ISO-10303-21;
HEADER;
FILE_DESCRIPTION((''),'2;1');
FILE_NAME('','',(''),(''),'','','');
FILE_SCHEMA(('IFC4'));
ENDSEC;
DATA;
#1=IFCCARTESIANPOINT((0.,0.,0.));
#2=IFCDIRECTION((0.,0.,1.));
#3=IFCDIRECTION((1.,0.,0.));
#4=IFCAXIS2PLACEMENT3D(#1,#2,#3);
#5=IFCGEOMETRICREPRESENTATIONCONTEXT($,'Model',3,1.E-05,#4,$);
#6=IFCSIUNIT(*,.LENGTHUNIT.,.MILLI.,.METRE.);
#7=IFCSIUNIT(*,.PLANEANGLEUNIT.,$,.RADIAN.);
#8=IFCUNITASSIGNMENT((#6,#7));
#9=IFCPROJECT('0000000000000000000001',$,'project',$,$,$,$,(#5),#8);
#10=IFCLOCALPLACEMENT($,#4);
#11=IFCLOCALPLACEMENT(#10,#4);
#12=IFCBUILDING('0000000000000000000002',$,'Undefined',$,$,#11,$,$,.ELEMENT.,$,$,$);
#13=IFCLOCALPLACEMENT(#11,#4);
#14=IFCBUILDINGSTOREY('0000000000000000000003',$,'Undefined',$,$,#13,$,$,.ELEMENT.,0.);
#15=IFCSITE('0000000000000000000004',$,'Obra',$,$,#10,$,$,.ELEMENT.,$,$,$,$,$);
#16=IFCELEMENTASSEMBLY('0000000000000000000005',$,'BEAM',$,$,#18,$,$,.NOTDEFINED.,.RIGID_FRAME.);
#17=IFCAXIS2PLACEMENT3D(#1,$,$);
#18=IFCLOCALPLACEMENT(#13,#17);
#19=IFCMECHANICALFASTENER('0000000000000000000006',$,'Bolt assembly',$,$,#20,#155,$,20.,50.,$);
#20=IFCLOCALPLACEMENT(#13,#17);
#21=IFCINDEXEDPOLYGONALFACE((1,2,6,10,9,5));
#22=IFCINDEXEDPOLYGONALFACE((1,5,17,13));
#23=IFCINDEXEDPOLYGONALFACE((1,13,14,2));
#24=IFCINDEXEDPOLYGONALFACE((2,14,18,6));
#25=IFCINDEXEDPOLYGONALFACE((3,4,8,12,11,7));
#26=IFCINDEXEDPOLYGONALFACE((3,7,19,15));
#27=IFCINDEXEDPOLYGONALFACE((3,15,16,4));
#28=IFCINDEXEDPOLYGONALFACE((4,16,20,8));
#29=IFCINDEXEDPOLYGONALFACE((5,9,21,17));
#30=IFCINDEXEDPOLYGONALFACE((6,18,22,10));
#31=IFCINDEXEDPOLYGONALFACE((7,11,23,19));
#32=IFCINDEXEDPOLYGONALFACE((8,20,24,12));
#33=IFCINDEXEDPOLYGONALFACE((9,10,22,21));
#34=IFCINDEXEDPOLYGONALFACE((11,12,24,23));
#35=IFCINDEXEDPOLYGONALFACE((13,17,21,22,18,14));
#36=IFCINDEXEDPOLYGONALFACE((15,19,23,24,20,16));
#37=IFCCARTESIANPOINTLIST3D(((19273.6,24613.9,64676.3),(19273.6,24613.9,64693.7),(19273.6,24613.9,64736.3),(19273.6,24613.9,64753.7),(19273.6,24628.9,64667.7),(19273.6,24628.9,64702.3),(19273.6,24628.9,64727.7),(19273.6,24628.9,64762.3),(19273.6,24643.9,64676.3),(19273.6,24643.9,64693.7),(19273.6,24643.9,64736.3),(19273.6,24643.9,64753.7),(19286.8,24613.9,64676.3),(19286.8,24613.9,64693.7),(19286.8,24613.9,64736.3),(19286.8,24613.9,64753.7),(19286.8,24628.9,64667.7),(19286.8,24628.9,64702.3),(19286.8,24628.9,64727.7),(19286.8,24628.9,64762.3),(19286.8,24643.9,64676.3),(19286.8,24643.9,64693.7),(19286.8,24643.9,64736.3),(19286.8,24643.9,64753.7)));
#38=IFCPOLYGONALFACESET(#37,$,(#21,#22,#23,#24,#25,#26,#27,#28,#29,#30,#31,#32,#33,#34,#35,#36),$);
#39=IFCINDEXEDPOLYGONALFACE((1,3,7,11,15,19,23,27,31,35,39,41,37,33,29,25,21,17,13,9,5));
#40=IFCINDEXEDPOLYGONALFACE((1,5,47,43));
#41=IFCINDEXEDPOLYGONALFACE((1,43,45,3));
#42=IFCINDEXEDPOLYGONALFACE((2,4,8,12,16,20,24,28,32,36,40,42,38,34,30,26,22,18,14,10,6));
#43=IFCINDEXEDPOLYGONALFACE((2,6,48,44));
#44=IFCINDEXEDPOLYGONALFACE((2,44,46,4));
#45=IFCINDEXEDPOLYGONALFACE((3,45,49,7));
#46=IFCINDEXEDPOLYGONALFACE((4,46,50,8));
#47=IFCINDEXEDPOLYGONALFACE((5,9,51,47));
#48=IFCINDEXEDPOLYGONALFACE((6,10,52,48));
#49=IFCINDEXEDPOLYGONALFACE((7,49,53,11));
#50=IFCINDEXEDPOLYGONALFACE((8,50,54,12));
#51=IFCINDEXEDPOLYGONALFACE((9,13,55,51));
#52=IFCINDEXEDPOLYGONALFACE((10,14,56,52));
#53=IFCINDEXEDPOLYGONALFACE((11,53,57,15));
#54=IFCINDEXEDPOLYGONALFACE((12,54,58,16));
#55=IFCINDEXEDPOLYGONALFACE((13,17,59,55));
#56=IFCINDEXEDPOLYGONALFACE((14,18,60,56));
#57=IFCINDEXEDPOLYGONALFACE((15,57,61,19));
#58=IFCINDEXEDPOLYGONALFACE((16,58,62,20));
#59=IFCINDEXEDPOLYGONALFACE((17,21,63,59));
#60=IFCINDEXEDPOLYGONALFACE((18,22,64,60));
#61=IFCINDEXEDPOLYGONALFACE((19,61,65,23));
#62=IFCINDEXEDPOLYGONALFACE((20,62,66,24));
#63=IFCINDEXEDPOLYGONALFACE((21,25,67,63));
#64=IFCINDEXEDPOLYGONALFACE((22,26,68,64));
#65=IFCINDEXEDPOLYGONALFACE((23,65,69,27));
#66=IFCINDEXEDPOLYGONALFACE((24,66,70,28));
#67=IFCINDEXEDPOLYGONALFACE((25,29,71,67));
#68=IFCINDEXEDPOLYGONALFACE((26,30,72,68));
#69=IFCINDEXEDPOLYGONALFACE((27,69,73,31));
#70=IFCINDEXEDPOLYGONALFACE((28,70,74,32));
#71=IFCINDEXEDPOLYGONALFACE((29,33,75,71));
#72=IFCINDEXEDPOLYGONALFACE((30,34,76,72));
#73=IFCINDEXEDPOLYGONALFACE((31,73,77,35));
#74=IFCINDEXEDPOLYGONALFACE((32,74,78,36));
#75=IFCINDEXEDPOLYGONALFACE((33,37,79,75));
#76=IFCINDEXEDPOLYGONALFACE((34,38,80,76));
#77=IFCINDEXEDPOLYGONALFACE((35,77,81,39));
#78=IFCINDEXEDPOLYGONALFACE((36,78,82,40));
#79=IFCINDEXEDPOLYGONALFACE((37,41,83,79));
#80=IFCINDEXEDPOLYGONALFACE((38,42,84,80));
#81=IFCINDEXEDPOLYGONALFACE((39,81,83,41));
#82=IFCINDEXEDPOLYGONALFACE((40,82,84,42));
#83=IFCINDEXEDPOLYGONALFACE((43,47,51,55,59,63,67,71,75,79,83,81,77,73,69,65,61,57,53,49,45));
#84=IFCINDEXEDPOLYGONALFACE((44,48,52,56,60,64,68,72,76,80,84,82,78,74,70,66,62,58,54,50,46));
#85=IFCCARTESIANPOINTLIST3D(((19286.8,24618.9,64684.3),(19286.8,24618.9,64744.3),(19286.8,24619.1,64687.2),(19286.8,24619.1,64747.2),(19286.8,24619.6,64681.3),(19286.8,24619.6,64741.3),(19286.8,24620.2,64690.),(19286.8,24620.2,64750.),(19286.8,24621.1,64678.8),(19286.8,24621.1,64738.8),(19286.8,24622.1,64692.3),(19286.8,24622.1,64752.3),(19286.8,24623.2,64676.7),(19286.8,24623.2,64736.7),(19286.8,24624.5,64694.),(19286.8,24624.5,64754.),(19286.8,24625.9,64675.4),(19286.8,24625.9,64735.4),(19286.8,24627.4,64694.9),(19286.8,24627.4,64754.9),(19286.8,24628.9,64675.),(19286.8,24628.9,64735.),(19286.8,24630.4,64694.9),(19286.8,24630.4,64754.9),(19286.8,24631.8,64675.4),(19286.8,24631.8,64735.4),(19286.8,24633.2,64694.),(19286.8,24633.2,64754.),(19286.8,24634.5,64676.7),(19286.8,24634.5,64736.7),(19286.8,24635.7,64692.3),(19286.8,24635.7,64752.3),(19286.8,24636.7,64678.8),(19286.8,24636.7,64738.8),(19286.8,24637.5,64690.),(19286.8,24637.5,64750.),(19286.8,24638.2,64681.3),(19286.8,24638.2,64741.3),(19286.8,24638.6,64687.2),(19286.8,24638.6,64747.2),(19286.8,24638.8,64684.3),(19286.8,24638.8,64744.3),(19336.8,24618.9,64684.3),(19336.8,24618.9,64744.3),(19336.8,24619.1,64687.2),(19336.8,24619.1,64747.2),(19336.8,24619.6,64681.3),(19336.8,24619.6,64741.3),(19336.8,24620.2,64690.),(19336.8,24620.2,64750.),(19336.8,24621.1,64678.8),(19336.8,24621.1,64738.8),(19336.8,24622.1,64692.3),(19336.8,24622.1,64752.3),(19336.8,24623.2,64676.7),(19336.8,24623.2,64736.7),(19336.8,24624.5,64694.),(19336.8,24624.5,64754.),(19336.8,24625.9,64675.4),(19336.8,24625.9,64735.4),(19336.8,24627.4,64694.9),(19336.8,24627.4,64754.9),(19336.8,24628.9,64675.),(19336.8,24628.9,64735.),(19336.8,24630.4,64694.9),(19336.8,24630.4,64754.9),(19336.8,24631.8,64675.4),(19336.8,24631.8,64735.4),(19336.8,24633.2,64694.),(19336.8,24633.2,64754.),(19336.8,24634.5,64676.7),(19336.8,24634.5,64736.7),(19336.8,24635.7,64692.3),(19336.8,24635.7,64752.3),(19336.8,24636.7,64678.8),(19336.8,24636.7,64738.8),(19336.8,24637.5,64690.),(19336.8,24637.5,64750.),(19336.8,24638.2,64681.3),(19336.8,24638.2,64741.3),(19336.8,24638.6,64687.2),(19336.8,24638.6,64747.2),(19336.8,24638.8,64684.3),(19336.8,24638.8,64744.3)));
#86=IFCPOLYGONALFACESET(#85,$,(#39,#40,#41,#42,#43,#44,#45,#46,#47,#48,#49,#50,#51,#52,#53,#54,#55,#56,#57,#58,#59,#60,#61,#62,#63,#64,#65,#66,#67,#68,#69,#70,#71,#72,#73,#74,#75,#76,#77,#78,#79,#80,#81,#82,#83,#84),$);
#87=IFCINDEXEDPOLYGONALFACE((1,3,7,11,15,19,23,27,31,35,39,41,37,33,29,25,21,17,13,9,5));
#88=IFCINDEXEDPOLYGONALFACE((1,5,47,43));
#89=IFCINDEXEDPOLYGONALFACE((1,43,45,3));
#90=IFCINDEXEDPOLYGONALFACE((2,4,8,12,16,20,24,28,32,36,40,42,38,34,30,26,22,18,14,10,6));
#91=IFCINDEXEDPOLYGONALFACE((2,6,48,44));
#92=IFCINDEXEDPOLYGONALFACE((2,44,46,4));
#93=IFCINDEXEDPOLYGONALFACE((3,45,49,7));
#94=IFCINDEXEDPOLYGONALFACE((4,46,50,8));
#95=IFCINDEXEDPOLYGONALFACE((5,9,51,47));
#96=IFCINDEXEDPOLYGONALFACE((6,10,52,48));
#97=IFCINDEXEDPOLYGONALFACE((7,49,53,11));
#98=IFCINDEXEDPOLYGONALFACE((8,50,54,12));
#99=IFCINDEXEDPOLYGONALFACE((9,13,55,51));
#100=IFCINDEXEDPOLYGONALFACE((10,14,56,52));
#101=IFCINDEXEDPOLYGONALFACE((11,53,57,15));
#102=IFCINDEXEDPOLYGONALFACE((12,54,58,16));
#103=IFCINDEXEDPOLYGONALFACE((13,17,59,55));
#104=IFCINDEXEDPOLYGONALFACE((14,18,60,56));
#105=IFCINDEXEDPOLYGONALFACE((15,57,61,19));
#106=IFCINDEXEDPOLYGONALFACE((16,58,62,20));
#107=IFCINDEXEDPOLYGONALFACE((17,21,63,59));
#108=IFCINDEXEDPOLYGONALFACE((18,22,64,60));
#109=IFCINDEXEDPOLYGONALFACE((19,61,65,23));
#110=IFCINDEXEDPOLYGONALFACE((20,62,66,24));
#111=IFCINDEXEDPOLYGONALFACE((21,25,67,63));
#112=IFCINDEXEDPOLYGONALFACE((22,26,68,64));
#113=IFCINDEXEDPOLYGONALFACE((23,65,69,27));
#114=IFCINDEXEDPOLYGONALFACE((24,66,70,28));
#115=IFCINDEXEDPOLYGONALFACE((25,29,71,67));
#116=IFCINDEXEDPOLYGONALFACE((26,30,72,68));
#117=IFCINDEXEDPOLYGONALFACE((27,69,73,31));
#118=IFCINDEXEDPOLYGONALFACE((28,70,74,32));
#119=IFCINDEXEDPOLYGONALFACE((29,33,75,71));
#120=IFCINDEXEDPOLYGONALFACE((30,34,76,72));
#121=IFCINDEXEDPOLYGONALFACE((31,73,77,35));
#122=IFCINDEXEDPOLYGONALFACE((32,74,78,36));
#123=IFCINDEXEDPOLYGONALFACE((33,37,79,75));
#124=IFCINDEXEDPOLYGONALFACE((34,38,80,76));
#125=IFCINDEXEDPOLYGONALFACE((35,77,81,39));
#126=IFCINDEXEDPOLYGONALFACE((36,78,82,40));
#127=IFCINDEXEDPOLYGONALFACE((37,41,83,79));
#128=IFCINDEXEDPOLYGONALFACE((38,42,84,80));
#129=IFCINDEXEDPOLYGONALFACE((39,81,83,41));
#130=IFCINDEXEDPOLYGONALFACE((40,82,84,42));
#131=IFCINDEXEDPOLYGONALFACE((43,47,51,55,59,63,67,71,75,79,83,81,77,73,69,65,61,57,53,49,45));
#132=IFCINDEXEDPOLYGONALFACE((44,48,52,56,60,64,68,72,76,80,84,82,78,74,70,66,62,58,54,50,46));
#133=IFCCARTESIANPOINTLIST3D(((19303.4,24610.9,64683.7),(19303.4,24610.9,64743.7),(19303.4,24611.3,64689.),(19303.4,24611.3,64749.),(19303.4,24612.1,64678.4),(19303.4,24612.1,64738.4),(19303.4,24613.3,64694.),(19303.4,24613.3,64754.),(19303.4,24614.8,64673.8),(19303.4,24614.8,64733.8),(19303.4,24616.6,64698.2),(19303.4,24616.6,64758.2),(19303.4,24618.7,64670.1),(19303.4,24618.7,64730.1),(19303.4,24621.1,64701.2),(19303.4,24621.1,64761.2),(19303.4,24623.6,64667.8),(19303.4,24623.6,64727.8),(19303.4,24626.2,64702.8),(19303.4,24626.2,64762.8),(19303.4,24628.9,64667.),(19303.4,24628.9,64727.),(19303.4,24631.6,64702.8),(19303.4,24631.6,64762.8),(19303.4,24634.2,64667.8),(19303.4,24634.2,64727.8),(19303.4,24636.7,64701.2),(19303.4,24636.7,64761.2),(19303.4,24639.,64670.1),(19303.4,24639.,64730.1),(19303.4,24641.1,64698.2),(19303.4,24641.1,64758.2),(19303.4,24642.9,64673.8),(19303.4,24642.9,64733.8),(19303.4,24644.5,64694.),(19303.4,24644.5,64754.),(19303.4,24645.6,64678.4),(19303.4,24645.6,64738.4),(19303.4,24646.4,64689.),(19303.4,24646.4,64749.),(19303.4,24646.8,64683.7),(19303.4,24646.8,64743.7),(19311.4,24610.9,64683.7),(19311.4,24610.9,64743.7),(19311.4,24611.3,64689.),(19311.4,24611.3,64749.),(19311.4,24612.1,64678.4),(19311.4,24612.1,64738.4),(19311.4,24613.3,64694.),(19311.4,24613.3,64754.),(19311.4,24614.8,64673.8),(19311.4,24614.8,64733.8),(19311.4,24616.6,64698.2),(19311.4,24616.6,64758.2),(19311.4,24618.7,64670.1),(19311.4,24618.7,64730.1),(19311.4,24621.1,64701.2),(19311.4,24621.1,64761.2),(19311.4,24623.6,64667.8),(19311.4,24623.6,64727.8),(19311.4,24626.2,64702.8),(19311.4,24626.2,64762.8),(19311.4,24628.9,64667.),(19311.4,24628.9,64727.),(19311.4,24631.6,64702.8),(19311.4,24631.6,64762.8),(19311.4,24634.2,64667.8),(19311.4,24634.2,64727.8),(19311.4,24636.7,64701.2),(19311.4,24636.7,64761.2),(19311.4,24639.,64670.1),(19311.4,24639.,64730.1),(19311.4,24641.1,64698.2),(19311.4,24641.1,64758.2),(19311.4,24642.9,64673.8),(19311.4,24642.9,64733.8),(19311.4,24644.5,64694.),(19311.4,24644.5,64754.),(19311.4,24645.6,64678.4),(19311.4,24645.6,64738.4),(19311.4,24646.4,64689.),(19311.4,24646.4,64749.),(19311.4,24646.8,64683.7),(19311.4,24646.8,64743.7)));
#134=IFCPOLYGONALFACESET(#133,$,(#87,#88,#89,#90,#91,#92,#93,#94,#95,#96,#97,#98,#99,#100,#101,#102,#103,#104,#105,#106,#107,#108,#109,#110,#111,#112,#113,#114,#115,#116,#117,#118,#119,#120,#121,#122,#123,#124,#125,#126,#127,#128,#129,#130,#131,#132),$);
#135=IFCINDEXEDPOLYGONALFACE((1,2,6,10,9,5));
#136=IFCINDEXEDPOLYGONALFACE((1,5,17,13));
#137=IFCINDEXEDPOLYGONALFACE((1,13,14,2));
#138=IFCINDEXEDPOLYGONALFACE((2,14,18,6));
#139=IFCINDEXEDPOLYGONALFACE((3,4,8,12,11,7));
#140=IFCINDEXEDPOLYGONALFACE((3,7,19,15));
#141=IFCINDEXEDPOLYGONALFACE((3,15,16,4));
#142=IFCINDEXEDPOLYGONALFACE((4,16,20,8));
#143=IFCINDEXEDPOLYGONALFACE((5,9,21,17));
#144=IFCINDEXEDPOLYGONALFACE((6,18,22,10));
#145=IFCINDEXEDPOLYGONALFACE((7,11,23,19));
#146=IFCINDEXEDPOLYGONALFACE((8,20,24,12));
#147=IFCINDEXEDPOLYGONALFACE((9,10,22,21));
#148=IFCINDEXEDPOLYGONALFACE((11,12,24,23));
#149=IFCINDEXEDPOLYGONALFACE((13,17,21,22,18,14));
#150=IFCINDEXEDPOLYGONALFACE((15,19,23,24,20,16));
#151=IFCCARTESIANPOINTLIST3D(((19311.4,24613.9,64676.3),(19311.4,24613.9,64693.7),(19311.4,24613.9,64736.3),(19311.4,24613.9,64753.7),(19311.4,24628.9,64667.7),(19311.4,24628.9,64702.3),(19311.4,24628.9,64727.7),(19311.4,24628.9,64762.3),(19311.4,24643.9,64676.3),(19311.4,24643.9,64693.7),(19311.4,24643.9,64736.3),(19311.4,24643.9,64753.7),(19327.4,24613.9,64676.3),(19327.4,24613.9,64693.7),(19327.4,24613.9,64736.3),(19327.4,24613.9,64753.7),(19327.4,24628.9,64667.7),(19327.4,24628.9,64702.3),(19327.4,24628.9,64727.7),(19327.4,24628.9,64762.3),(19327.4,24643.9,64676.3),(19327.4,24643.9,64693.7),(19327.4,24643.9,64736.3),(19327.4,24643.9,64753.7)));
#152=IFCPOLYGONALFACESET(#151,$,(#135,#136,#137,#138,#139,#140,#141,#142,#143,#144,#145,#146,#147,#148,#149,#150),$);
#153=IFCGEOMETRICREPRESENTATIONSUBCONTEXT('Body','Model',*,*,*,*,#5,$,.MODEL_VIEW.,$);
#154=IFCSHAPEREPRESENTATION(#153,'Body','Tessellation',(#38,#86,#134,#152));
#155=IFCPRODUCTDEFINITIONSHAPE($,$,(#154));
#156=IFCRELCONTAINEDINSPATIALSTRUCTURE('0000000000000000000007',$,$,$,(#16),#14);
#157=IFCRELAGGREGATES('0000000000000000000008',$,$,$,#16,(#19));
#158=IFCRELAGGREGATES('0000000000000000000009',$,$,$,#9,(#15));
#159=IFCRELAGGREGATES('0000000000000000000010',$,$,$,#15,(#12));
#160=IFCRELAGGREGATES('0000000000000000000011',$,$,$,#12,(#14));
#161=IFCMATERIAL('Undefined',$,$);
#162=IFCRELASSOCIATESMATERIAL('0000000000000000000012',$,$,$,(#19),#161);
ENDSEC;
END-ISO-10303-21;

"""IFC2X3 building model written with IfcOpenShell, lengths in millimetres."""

from ifc_helpers import new_model, si_unit, frame, origin_with_axes, origin_2d_with_axis, place, context, subcontext, project, spatial, polyline, circle, outline, extrude, source, transform, mapped, material, element, aggregate, save


model = new_model("IFC2X3")

# Units and contexts
model_context = context("Model", 3, precision=1e-05, world=origin_with_axes())
body_context = subcontext(model_context, "Body", "Model", "MODEL_VIEW")
ifc_project = project(units=[si_unit("LENGTHUNIT", "METRE", prefix="MILLI"), si_unit("PLANEANGLEUNIT", "RADIAN")], contexts=[model_context])

# Site, building, storey
site_placement = place(None, origin_with_axes())
site = spatial("IfcSite", under=ifc_project, at=site_placement, Name="Obra", CompositionType="ELEMENT")
building_placement = place(site_placement, origin_with_axes())
building = spatial("IfcBuilding", under=site, at=building_placement, Name="Undefined", CompositionType="ELEMENT")
storey_placement = place(building_placement, origin_with_axes())
storey = spatial("IfcBuildingStorey", under=building, at=storey_placement, Name="Undefined", CompositionType="ELEMENT", Elevation=0.0)

# Shared definitions
ifc_material = material(Name="Undefined")

# Element assembly
assembly_1_placement = place(storey_placement, origin_with_axes())
assembly_1 = element("IfcElementAssembly", 1, at=assembly_1_placement, inside=storey, Name="BEAM", AssemblyPlace="NOTDEFINED", PredefinedType="RIGID_FRAME")

# Mechanical fastener
shared_shape_1 = source(origin_with_axes(), body_context, "Body", "SweptSolid", [
    extrude(outline(polyline([(17.3, 0.0), (8.7, 15.0), (-8.7, 15.0), (-17.3, 0.0), (-8.7, -15.0), (8.7, -15.0), (17.3, 0.0)])), frame((0.0, -26.5, 0.0), z_axis=(0.0, 1.0, 0.0), x_axis=(1.0, 0.0, 0.0)), (0.0, 0.0, 1.0), 13.2),
    extrude(circle(Radius=10.0, at=origin_2d_with_axis()), frame((0.0, -13.3, 0.0), z_axis=(0.0, 1.0, 0.0), x_axis=(1.0, 0.0, 0.0)), (0.0, 0.0, 1.0), 50.0),
    extrude(circle(Radius=18.0, at=origin_2d_with_axis()), frame((0.0, 3.3, 0.0), z_axis=(0.0, 1.0, 0.0), x_axis=(1.0, 0.0, 0.0)), (0.0, 0.0, 1.0), 8.0),
    extrude(outline(polyline([(17.3, 0.0), (8.7, 15.0), (-8.7, 15.0), (-17.3, 0.0), (-8.7, -15.0), (8.7, -15.0), (17.3, 0.0)])), frame((0.0, 11.3, 0.0), z_axis=(0.0, 1.0, 0.0), x_axis=(1.0, 0.0, 0.0)), (0.0, 0.0, 1.0), 16.0),
])
mechanical_fastener_1_placement = place(assembly_1_placement, frame((19300.1, 24668.9, 64850.0), z_axis=(0.000002, -1.0, 0.0), x_axis=(0.0, 0.0, -1.0)))
mechanical_fastener_1 = element("IfcMechanicalFastener", 2, at=mechanical_fastener_1_placement, material=ifc_material, Name="Bolt assembly", NominalDiameter=20.0, NominalLength=50.0, context=body_context, shape_type="MappedRepresentation", body=[
    mapped(shared_shape_1, transform((105.0, 0.0, 40.0))),
    mapped(shared_shape_1, transform((165.0, 0.0, 40.0))),
])
aggregate(assembly_1, [mechanical_fastener_1])

save(model, "model.ifc")
